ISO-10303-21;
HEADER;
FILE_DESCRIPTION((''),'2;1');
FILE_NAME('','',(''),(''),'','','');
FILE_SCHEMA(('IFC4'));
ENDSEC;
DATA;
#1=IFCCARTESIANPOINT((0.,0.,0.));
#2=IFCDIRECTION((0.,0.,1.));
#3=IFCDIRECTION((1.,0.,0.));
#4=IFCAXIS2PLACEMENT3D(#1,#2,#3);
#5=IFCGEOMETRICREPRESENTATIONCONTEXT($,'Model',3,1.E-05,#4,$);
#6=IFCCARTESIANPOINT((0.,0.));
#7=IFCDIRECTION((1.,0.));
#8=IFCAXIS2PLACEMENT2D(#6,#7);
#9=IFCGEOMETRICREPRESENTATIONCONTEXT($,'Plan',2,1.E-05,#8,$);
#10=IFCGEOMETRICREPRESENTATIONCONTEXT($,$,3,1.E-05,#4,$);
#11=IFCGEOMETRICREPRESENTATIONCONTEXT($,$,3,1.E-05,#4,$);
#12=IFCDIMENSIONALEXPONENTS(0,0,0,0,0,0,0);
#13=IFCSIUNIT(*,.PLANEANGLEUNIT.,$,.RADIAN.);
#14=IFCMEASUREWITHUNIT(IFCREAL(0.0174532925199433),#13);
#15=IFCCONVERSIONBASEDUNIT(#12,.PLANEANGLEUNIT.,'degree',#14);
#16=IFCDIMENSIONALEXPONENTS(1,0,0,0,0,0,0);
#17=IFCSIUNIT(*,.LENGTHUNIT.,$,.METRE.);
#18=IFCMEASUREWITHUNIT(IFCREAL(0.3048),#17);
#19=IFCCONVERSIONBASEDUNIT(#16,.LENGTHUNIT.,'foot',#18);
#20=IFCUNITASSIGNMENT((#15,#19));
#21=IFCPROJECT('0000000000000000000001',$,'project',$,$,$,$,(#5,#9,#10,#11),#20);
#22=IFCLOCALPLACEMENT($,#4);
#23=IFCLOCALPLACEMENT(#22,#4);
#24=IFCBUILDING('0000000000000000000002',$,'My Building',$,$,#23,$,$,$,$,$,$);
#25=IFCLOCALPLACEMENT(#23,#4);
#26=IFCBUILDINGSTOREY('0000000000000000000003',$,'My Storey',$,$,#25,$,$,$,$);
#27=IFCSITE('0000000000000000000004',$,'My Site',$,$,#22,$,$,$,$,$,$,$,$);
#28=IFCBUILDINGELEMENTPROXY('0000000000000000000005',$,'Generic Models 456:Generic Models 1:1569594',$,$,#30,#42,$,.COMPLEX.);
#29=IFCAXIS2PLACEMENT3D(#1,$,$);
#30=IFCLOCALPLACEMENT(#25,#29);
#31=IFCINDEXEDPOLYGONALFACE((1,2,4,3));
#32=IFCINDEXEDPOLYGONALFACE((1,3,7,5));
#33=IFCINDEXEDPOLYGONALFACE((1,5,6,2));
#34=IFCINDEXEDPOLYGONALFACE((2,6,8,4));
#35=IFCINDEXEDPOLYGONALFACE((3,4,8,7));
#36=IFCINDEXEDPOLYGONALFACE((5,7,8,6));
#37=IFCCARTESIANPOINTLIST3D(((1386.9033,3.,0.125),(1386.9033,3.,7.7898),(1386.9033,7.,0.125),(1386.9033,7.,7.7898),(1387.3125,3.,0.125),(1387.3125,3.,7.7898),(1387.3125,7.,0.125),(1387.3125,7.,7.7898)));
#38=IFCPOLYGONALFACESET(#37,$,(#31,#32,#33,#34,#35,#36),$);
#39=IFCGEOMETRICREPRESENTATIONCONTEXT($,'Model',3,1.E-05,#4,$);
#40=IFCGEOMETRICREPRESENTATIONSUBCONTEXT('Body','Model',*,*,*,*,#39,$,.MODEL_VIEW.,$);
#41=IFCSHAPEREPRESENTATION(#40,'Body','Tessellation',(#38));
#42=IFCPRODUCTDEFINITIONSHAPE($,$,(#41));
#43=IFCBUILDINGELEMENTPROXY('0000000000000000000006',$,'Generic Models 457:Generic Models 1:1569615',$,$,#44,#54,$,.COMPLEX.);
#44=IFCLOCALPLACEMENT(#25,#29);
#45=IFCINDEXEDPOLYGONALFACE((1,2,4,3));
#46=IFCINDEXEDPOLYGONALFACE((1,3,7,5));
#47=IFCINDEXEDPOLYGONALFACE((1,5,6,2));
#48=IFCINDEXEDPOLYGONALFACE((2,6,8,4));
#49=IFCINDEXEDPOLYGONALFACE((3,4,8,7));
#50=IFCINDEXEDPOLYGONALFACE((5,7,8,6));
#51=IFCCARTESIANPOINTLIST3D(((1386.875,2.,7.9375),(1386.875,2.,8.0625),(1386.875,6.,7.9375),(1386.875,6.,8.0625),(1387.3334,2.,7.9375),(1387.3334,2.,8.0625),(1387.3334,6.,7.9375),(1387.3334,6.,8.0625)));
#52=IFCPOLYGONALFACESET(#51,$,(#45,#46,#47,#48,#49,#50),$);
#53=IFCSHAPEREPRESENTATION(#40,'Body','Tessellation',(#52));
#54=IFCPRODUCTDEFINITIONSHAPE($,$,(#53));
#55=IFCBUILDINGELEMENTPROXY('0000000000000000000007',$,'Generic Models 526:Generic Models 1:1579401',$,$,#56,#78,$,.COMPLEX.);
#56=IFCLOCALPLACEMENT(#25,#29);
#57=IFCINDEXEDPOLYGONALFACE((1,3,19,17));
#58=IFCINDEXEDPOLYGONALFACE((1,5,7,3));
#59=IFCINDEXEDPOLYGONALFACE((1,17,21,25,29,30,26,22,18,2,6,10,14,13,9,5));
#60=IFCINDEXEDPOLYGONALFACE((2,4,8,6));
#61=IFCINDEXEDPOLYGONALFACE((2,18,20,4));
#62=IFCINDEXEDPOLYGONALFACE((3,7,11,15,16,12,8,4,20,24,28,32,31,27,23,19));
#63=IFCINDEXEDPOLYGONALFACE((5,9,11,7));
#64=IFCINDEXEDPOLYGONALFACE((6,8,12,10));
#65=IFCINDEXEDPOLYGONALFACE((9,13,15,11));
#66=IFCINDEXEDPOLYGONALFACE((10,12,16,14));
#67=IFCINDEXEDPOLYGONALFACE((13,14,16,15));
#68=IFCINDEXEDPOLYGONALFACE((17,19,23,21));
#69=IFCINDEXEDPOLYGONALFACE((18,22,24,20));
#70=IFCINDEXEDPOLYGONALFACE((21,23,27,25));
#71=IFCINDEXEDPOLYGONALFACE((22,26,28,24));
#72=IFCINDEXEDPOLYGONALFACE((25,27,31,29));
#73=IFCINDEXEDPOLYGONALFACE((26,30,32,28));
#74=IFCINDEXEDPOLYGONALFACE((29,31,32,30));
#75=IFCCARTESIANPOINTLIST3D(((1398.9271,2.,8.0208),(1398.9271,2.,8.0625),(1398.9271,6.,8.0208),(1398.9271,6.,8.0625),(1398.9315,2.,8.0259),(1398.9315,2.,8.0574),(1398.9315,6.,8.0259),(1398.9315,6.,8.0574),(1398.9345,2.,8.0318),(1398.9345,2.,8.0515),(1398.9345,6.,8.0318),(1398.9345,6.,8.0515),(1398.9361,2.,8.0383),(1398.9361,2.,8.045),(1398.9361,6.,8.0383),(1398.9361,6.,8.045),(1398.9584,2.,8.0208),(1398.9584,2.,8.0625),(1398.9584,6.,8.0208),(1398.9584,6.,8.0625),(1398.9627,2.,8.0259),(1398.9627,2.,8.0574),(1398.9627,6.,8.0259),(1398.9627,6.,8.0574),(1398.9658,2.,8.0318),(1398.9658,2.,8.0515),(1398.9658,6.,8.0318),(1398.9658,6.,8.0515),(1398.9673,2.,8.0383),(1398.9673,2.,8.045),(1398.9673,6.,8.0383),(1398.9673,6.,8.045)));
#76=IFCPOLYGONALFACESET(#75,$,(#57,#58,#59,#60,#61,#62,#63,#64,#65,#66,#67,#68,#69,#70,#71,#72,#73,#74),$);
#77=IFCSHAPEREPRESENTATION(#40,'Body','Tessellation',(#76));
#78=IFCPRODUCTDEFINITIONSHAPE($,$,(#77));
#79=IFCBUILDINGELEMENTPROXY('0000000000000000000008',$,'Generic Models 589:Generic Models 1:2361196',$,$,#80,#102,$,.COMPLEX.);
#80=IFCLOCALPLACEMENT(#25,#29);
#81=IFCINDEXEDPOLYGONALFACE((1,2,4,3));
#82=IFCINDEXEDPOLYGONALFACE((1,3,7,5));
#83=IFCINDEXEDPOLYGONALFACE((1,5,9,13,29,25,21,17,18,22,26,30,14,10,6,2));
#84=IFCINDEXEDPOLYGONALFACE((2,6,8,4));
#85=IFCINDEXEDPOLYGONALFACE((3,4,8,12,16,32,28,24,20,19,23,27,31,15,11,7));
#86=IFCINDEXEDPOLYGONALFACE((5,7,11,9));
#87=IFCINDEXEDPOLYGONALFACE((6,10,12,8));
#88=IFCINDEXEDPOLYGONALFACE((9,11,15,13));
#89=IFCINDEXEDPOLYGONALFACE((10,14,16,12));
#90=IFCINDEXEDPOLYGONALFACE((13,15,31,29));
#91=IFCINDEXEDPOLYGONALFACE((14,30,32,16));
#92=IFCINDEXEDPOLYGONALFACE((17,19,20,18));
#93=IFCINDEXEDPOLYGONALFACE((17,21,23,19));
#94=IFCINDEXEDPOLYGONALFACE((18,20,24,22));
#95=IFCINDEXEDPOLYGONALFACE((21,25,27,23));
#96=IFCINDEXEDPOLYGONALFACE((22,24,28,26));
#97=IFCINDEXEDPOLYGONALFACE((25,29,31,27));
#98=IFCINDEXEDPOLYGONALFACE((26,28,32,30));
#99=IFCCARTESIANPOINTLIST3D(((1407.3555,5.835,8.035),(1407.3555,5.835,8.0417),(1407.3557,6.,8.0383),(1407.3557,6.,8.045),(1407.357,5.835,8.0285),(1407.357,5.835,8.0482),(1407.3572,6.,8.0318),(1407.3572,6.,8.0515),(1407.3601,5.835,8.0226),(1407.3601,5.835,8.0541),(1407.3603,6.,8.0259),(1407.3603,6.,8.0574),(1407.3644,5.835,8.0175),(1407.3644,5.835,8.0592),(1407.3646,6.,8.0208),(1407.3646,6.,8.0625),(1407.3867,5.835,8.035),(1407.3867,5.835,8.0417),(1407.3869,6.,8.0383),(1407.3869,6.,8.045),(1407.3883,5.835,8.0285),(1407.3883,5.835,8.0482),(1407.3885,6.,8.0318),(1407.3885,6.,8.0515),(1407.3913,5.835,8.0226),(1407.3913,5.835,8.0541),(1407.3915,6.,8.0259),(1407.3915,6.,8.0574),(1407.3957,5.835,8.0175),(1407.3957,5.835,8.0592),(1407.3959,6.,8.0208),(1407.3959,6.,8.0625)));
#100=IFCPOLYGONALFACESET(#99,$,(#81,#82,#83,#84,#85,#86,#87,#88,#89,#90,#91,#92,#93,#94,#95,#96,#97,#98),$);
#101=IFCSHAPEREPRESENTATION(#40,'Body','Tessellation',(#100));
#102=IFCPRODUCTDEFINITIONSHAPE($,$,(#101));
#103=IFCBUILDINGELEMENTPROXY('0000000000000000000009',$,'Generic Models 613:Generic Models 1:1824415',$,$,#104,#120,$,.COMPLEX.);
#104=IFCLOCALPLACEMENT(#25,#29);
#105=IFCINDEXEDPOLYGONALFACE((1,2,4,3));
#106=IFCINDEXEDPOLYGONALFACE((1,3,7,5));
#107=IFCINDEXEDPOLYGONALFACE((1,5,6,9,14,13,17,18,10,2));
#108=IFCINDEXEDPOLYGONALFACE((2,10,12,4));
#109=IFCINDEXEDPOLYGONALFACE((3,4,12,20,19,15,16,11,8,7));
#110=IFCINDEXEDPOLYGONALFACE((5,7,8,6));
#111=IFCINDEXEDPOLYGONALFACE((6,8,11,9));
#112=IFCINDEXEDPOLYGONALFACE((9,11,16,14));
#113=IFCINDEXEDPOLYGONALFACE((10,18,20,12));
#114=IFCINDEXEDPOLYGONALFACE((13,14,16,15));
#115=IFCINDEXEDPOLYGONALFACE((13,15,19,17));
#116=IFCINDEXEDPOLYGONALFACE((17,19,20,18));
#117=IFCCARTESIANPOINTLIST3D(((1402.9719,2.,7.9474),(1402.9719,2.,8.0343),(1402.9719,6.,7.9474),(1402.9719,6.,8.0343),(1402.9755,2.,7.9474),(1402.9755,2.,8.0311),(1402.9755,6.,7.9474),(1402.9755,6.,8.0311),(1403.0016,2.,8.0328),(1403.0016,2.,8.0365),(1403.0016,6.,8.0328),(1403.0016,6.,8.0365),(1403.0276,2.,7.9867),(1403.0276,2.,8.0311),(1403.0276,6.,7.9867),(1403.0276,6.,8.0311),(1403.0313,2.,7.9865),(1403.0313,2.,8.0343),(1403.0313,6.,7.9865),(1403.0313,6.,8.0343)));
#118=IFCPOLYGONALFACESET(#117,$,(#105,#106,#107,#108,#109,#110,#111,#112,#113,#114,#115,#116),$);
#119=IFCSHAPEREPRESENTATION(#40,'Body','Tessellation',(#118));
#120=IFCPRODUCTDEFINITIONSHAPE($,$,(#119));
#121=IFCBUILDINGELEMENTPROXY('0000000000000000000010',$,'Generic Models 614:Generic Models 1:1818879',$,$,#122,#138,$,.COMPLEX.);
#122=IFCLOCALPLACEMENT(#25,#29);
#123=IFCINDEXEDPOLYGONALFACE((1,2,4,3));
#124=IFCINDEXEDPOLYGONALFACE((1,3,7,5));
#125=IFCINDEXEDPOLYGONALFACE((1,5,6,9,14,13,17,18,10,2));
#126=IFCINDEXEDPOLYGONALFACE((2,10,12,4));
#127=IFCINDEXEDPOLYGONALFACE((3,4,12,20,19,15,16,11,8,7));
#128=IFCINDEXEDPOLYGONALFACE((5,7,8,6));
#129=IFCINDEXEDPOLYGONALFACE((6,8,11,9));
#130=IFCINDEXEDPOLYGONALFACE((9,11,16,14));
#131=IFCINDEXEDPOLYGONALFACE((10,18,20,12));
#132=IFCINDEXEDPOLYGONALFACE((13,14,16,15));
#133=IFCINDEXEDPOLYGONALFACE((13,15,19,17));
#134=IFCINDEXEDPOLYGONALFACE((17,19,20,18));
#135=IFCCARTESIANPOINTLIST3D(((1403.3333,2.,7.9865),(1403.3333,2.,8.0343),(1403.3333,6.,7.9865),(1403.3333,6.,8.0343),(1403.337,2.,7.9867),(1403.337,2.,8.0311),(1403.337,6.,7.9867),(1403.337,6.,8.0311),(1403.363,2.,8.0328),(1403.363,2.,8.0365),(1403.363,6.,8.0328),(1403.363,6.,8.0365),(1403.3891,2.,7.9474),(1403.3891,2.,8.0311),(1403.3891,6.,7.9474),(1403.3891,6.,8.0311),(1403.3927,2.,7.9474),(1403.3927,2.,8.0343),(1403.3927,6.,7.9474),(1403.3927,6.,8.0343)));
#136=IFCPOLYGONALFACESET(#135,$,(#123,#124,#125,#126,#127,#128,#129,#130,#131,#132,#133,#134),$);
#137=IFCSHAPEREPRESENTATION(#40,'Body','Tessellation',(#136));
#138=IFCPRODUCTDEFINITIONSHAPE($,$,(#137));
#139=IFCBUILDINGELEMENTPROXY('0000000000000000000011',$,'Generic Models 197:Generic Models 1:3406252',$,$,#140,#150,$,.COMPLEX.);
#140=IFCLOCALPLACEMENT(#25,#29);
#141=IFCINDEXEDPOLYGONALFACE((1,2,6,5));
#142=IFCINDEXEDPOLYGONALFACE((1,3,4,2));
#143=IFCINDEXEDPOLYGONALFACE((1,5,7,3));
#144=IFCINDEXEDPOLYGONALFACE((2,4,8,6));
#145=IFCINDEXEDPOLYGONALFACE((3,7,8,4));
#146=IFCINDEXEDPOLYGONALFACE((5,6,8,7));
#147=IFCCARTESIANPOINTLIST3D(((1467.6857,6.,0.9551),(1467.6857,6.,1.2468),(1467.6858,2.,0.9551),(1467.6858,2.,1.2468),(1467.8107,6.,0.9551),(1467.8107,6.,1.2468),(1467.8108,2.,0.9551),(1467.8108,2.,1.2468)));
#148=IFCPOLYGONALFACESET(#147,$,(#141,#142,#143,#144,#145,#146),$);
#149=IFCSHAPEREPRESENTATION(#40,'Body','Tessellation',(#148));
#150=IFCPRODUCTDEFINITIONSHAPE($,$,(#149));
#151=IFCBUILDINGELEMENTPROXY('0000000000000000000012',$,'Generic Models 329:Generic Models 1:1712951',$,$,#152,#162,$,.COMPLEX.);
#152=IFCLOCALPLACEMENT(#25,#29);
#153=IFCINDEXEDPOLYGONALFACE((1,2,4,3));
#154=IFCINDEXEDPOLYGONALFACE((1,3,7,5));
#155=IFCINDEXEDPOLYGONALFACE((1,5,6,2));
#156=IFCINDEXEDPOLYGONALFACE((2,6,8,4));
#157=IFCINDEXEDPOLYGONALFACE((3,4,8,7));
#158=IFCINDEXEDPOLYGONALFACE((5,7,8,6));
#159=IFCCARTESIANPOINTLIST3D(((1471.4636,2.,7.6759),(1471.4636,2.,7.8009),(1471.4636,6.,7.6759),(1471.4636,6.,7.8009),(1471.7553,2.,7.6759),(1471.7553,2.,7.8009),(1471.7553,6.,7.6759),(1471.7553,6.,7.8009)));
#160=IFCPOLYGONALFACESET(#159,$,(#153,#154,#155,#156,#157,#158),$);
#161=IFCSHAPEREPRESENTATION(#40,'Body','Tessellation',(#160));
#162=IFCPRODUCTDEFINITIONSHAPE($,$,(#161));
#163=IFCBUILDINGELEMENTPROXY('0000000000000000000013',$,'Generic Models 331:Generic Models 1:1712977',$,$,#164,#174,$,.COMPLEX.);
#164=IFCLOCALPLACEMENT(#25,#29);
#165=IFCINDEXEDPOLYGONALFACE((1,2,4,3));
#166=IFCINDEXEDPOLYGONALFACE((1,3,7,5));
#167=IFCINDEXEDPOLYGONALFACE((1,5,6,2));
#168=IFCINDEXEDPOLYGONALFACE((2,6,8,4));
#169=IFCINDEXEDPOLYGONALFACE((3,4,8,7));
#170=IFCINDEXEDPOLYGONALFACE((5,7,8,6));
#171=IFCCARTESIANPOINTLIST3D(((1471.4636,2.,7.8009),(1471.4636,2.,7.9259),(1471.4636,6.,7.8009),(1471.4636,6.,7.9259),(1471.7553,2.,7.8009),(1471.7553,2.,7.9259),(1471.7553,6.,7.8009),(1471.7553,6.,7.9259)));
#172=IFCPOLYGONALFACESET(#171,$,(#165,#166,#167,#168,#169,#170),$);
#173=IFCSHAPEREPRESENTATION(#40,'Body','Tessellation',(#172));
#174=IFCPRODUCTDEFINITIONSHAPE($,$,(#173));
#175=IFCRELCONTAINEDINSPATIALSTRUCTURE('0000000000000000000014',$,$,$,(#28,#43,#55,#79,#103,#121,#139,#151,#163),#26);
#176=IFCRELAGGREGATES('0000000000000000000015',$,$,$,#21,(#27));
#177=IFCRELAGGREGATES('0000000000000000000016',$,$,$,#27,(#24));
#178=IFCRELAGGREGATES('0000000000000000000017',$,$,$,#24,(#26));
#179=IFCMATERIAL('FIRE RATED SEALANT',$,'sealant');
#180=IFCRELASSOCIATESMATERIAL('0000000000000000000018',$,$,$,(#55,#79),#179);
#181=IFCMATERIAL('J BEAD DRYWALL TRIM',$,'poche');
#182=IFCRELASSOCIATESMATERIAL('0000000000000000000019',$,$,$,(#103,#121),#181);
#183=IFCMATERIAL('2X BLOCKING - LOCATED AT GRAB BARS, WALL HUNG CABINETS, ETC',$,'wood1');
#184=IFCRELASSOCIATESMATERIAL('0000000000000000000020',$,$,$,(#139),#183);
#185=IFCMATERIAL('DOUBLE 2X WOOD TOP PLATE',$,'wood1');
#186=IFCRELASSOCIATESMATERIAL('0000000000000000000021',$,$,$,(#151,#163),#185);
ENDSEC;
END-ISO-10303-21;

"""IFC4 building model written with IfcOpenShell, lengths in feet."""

from ifc_helpers import new_model, entity, si_unit, converted_unit, frame, origin_with_axes, origin_2d_with_axis, place, context, subcontext, project, spatial, polyline, line, indexed_curve, outline, extrude, material, element, save


model = new_model("IFC4")

# Units and contexts
model_context_1 = context("Model", 3, precision=1e-05, world=origin_with_axes())
plan_context = context("Plan", 2, precision=1e-05, world=origin_2d_with_axis())
model_context_2 = context("Model", 3, precision=1e-05, world=origin_with_axes())
context_of_model_1 = context(None, 3, precision=1e-05, world=origin_with_axes())
context_of_model_2 = context(None, 3, precision=1e-05, world=origin_with_axes())
body_context = subcontext(model_context_2, "Body", "Model", "MODEL_VIEW")
ifc_project = project(units=[converted_unit("PLANEANGLEUNIT", "degree", entity("IfcReal", 0.0174532925199433), si_unit("PLANEANGLEUNIT", "RADIAN"), dimensions=[0, 0, 0, 0, 0, 0, 0]), converted_unit("LENGTHUNIT", "foot", entity("IfcReal", 0.3048), si_unit("LENGTHUNIT", "METRE"), dimensions=[1, 0, 0, 0, 0, 0, 0])], contexts=[model_context_1, plan_context, context_of_model_1, context_of_model_2])

# Site, building, storey
site_placement = place(None, origin_with_axes())
site = spatial("IfcSite", under=ifc_project, at=site_placement, Name="My Site")
building_placement = place(site_placement, origin_with_axes())
building = spatial("IfcBuilding", under=site, at=building_placement, Name="My Building")
storey_placement = place(building_placement, origin_with_axes())
storey = spatial("IfcBuildingStorey", under=building, at=storey_placement, Name="My Storey")

# Building element proxies
ifc_material_1 = material(Name="FIRE RATED SEALANT", Category="sealant")
ifc_material_2 = material(Name="2X BLOCKING - LOCATED AT GRAB BARS, WALL HUNG CABINETS, ETC", Category="wood1")
proxy_1_placement = place(storey_placement, frame((1386.9033, 7.0, 0.125), z_axis=(0.0, -1.0, 0.0), x_axis=(0.0, 0.0, 1.0)))
element("IfcBuildingElementProxy", 1, at=proxy_1_placement, inside=storey, Name="Generic Models 456:Generic Models 1:1569594", PredefinedType="COMPLEX", context=body_context, shape_type="SweptSolid", body=[
    extrude(outline(polyline([(-0.2046, -3.8324), (0.2046, -3.8324), (0.2046, 3.8324), (-0.2046, 3.8324), (-0.2046, -3.8324)])), frame((3.8324, -0.2046, 0.0), z_axis=(0.0, 0.0, -1.0), x_axis=(0.0, 1.0, 0.0)), (0.0, 0.0, -1.0), 4.0),
])
proxy_2_placement = place(storey_placement, frame((1386.875, 6.0, 7.9375), z_axis=(0.0, -1.0, 0.0), x_axis=(0.0, 0.0, 1.0)))
element("IfcBuildingElementProxy", 2, at=proxy_2_placement, inside=storey, Name="Generic Models 457:Generic Models 1:1569615", PredefinedType="COMPLEX", context=body_context, shape_type="SweptSolid", body=[
    extrude(outline(polyline([(-0.2292, -0.0625), (0.2292, -0.0625), (0.2292, 0.0625), (-0.2292, 0.0625), (-0.2292, -0.0625)])), frame((0.0625, -0.2292, 0.0), z_axis=(0.0, 0.0, -1.0), x_axis=(0.0, 1.0, 0.0)), (0.0, 0.0, -1.0), 4.0),
])
proxy_3_placement = place(storey_placement, frame((1398.9271, 6.0, 8.0208), z_axis=(0.0, -1.0, 0.0), x_axis=(0.0, 0.0, 1.0)))
element("IfcBuildingElementProxy", 3, at=proxy_3_placement, inside=storey, material=ifc_material_1, Name="Generic Models 526:Generic Models 1:1579401", PredefinedType="COMPLEX", context=body_context, shape_type="SweptSolid", body=[
    extrude(outline(polyline([(0.0216, 0.0), (0.0223, 0.0066), (0.001, 0.0294), (0.0002, 0.0228), (-0.002, 0.0165), (-0.0057, 0.0109), (-0.0105, 0.0064), (-0.0163, 0.0031), (-0.0228, 0.0012), (-0.0294, 0.0009), (-0.008, -0.0219), (-0.0014, -0.0216), (0.005, -0.0197), (0.0108, -0.0164), (0.0157, -0.0119), (0.0194, -0.0063), (0.0216, 0.0)])), frame((0.0208, -0.0208, 0.0), z_axis=(0.0, 0.0, -1.0), x_axis=(-0.729168, -0.684334, 0.0)), (0.0, 0.0, -1.0), 4.0),
])
proxy_4_placement = place(storey_placement, frame((1407.3557, 6.0, 8.0208), z_axis=(0.0, -1.0, 0.0), x_axis=(0.0, 0.0, 1.0)))
element("IfcBuildingElementProxy", 4, at=proxy_4_placement, inside=storey, material=ifc_material_1, Name="Generic Models 589:Generic Models 1:2361196", PredefinedType="COMPLEX", context=body_context, shape_type="SweptSolid", body=[
    extrude(outline(polyline([(0.0204, 0.0), (0.0206, 0.0067), (0.0192, 0.0132), (-0.0082, 0.0283), (-0.0068, 0.0217), (-0.007, 0.0151), (-0.0088, 0.0086), (-0.012, 0.0028), (-0.0165, -0.0021), (-0.022, -0.0059), (-0.0283, -0.0082), (-0.0009, -0.0233), (0.0054, -0.021), (0.0109, -0.0172), (0.0154, -0.0123), (0.0186, -0.0064), (0.0204, 0.0)])), frame((0.0208, -0.0194, 0.0), z_axis=(0.0, 0.0, -1.0), x_axis=(0.482454, 0.875921, 0.0)), (-0.008711, -0.018298, -0.999795), 0.165),
])
ifc_material_3 = material(Name="J BEAD DRYWALL TRIM", Category="poche")
proxy_5_placement = place(storey_placement, frame((1402.9719, 6.0, 7.9474), z_axis=(0.0, -1.0, 0.0), x_axis=(0.0, 0.0, 1.0)))
element("IfcBuildingElementProxy", 5, at=proxy_5_placement, inside=storey, material=ifc_material_3, Name="Generic Models 613:Generic Models 1:1824415", PredefinedType="COMPLEX", context=body_context, shape_type="SweptSolid", body=[
    extrude(outline(indexed_curve([(-0.0243, 0.026), (0.0594, 0.026), (0.0594, 0.0297), (-0.0275, 0.0297), (-0.0296, 0.0), (-0.0275, -0.0297), (0.0203, -0.0297), (0.0201, -0.026), (-0.0243, -0.026), (-0.026, 0.0)], segments=[line(5, 4), line(4, 3), line(3, 2), line(2, 1), line(1, 10), line(10, 9), line(9, 8), line(8, 7), line(7, 6), line(6, 5)], self_intersect=False)), frame((0.0594, -0.0297, 0.0), z_axis=(0.0, 0.0, -1.0), x_axis=(-1.0, 0.0, 0.0)), (0.0, 0.0, -1.0), 4.0),
])
proxy_6_placement = place(storey_placement, frame((1403.3333, 6.0, 7.9474), z_axis=(0.0, -1.0, 0.0), x_axis=(0.0, 0.0, 1.0)))
element("IfcBuildingElementProxy", 6, at=proxy_6_placement, inside=storey, material=ifc_material_3, Name="Generic Models 614:Generic Models 1:1818879", PredefinedType="COMPLEX", context=body_context, shape_type="SweptSolid", body=[
    extrude(outline(indexed_curve([(-0.0203, -0.0297), (0.0275, -0.0297), (0.0296, 0.0), (0.0275, 0.0297), (-0.0594, 0.0297), (-0.0594, 0.026), (0.0243, 0.026), (0.026, 0.0), (0.0243, -0.026), (-0.0201, -0.026)], segments=[line(3, 2), line(2, 1), line(1, 10), line(10, 9), line(9, 8), line(8, 7), line(7, 6), line(6, 5), line(5, 4), line(4, 3)], self_intersect=False)), frame((0.0594, -0.0297, 0.0), z_axis=(0.0, 0.0, -1.0), x_axis=(1.0, 0.0, 0.0)), (0.0, 0.0, -1.0), 4.0),
])
for number, where, z_axis, x_axis, name in (
    (7, (1467.6857, 6.0, 0.9551), (0.0, -1.0, 0.0), (0.0, 0.0, 1.0), "Generic Models 197:Generic Models 1:3406252"),
):
    element("IfcBuildingElementProxy", number, at=place(storey_placement, frame(where, z_axis=z_axis, x_axis=x_axis)), inside=storey, material=ifc_material_2, Name=name, PredefinedType="COMPLEX", context=body_context, shape_type="SweptSolid", body=[
        extrude(outline(polyline([(-0.0625, -0.1458), (0.0625, -0.1458), (0.0625, 0.1458), (-0.0625, 0.1458), (-0.0625, -0.1458)])), frame((0.1458, -0.0625, 0.0), z_axis=(0.0, 0.0, -1.0), x_axis=(0.0, 1.0, 0.0)), (0.0, 0.0, -1.0), 4.0),
    ])
ifc_material_4 = material(Name="DOUBLE 2X WOOD TOP PLATE", Category="wood1")
proxy_7_placement = place(storey_placement, frame((1471.4636, 6.0, 7.6759), z_axis=(0.0, -1.0, 0.0), x_axis=(0.0, 0.0, 1.0)))
element("IfcBuildingElementProxy", 8, at=proxy_7_placement, inside=storey, material=ifc_material_4, Name="Generic Models 329:Generic Models 1:1712951", PredefinedType="COMPLEX", context=body_context, shape_type="SweptSolid", body=[
    extrude(outline(indexed_curve([(-0.1458, -0.0625), (0.1458, -0.0625), (0.1458, 0.0625), (-0.1458, 0.0625)], segments=[line(3, 2), line(2, 1), line(1, 4), line(4, 3)], self_intersect=False)), frame((0.0625, -0.1458, 0.0), z_axis=(0.0, 0.0, -1.0), x_axis=(0.0, 1.0, 0.0)), (0.0, 0.0, -1.0), 4.0),
])
proxy_8_placement = place(storey_placement, frame((1471.4636, 6.0, 7.8009), z_axis=(0.0, -1.0, 0.0), x_axis=(0.0, 0.0, 1.0)))
element("IfcBuildingElementProxy", 9, at=proxy_8_placement, inside=storey, material=ifc_material_4, Name="Generic Models 331:Generic Models 1:1712977", PredefinedType="COMPLEX", context=body_context, shape_type="SweptSolid", body=[
    extrude(outline(polyline([(-0.1458, -0.0625), (0.1458, -0.0625), (0.1458, 0.0625), (-0.1458, 0.0625), (-0.1458, -0.0625)])), frame((0.0625, -0.1458, 0.0), z_axis=(0.0, 0.0, -1.0), x_axis=(0.0, 1.0, 0.0)), (0.0, 0.0, -1.0), 4.0),
])

save(model, "model.ifc")
